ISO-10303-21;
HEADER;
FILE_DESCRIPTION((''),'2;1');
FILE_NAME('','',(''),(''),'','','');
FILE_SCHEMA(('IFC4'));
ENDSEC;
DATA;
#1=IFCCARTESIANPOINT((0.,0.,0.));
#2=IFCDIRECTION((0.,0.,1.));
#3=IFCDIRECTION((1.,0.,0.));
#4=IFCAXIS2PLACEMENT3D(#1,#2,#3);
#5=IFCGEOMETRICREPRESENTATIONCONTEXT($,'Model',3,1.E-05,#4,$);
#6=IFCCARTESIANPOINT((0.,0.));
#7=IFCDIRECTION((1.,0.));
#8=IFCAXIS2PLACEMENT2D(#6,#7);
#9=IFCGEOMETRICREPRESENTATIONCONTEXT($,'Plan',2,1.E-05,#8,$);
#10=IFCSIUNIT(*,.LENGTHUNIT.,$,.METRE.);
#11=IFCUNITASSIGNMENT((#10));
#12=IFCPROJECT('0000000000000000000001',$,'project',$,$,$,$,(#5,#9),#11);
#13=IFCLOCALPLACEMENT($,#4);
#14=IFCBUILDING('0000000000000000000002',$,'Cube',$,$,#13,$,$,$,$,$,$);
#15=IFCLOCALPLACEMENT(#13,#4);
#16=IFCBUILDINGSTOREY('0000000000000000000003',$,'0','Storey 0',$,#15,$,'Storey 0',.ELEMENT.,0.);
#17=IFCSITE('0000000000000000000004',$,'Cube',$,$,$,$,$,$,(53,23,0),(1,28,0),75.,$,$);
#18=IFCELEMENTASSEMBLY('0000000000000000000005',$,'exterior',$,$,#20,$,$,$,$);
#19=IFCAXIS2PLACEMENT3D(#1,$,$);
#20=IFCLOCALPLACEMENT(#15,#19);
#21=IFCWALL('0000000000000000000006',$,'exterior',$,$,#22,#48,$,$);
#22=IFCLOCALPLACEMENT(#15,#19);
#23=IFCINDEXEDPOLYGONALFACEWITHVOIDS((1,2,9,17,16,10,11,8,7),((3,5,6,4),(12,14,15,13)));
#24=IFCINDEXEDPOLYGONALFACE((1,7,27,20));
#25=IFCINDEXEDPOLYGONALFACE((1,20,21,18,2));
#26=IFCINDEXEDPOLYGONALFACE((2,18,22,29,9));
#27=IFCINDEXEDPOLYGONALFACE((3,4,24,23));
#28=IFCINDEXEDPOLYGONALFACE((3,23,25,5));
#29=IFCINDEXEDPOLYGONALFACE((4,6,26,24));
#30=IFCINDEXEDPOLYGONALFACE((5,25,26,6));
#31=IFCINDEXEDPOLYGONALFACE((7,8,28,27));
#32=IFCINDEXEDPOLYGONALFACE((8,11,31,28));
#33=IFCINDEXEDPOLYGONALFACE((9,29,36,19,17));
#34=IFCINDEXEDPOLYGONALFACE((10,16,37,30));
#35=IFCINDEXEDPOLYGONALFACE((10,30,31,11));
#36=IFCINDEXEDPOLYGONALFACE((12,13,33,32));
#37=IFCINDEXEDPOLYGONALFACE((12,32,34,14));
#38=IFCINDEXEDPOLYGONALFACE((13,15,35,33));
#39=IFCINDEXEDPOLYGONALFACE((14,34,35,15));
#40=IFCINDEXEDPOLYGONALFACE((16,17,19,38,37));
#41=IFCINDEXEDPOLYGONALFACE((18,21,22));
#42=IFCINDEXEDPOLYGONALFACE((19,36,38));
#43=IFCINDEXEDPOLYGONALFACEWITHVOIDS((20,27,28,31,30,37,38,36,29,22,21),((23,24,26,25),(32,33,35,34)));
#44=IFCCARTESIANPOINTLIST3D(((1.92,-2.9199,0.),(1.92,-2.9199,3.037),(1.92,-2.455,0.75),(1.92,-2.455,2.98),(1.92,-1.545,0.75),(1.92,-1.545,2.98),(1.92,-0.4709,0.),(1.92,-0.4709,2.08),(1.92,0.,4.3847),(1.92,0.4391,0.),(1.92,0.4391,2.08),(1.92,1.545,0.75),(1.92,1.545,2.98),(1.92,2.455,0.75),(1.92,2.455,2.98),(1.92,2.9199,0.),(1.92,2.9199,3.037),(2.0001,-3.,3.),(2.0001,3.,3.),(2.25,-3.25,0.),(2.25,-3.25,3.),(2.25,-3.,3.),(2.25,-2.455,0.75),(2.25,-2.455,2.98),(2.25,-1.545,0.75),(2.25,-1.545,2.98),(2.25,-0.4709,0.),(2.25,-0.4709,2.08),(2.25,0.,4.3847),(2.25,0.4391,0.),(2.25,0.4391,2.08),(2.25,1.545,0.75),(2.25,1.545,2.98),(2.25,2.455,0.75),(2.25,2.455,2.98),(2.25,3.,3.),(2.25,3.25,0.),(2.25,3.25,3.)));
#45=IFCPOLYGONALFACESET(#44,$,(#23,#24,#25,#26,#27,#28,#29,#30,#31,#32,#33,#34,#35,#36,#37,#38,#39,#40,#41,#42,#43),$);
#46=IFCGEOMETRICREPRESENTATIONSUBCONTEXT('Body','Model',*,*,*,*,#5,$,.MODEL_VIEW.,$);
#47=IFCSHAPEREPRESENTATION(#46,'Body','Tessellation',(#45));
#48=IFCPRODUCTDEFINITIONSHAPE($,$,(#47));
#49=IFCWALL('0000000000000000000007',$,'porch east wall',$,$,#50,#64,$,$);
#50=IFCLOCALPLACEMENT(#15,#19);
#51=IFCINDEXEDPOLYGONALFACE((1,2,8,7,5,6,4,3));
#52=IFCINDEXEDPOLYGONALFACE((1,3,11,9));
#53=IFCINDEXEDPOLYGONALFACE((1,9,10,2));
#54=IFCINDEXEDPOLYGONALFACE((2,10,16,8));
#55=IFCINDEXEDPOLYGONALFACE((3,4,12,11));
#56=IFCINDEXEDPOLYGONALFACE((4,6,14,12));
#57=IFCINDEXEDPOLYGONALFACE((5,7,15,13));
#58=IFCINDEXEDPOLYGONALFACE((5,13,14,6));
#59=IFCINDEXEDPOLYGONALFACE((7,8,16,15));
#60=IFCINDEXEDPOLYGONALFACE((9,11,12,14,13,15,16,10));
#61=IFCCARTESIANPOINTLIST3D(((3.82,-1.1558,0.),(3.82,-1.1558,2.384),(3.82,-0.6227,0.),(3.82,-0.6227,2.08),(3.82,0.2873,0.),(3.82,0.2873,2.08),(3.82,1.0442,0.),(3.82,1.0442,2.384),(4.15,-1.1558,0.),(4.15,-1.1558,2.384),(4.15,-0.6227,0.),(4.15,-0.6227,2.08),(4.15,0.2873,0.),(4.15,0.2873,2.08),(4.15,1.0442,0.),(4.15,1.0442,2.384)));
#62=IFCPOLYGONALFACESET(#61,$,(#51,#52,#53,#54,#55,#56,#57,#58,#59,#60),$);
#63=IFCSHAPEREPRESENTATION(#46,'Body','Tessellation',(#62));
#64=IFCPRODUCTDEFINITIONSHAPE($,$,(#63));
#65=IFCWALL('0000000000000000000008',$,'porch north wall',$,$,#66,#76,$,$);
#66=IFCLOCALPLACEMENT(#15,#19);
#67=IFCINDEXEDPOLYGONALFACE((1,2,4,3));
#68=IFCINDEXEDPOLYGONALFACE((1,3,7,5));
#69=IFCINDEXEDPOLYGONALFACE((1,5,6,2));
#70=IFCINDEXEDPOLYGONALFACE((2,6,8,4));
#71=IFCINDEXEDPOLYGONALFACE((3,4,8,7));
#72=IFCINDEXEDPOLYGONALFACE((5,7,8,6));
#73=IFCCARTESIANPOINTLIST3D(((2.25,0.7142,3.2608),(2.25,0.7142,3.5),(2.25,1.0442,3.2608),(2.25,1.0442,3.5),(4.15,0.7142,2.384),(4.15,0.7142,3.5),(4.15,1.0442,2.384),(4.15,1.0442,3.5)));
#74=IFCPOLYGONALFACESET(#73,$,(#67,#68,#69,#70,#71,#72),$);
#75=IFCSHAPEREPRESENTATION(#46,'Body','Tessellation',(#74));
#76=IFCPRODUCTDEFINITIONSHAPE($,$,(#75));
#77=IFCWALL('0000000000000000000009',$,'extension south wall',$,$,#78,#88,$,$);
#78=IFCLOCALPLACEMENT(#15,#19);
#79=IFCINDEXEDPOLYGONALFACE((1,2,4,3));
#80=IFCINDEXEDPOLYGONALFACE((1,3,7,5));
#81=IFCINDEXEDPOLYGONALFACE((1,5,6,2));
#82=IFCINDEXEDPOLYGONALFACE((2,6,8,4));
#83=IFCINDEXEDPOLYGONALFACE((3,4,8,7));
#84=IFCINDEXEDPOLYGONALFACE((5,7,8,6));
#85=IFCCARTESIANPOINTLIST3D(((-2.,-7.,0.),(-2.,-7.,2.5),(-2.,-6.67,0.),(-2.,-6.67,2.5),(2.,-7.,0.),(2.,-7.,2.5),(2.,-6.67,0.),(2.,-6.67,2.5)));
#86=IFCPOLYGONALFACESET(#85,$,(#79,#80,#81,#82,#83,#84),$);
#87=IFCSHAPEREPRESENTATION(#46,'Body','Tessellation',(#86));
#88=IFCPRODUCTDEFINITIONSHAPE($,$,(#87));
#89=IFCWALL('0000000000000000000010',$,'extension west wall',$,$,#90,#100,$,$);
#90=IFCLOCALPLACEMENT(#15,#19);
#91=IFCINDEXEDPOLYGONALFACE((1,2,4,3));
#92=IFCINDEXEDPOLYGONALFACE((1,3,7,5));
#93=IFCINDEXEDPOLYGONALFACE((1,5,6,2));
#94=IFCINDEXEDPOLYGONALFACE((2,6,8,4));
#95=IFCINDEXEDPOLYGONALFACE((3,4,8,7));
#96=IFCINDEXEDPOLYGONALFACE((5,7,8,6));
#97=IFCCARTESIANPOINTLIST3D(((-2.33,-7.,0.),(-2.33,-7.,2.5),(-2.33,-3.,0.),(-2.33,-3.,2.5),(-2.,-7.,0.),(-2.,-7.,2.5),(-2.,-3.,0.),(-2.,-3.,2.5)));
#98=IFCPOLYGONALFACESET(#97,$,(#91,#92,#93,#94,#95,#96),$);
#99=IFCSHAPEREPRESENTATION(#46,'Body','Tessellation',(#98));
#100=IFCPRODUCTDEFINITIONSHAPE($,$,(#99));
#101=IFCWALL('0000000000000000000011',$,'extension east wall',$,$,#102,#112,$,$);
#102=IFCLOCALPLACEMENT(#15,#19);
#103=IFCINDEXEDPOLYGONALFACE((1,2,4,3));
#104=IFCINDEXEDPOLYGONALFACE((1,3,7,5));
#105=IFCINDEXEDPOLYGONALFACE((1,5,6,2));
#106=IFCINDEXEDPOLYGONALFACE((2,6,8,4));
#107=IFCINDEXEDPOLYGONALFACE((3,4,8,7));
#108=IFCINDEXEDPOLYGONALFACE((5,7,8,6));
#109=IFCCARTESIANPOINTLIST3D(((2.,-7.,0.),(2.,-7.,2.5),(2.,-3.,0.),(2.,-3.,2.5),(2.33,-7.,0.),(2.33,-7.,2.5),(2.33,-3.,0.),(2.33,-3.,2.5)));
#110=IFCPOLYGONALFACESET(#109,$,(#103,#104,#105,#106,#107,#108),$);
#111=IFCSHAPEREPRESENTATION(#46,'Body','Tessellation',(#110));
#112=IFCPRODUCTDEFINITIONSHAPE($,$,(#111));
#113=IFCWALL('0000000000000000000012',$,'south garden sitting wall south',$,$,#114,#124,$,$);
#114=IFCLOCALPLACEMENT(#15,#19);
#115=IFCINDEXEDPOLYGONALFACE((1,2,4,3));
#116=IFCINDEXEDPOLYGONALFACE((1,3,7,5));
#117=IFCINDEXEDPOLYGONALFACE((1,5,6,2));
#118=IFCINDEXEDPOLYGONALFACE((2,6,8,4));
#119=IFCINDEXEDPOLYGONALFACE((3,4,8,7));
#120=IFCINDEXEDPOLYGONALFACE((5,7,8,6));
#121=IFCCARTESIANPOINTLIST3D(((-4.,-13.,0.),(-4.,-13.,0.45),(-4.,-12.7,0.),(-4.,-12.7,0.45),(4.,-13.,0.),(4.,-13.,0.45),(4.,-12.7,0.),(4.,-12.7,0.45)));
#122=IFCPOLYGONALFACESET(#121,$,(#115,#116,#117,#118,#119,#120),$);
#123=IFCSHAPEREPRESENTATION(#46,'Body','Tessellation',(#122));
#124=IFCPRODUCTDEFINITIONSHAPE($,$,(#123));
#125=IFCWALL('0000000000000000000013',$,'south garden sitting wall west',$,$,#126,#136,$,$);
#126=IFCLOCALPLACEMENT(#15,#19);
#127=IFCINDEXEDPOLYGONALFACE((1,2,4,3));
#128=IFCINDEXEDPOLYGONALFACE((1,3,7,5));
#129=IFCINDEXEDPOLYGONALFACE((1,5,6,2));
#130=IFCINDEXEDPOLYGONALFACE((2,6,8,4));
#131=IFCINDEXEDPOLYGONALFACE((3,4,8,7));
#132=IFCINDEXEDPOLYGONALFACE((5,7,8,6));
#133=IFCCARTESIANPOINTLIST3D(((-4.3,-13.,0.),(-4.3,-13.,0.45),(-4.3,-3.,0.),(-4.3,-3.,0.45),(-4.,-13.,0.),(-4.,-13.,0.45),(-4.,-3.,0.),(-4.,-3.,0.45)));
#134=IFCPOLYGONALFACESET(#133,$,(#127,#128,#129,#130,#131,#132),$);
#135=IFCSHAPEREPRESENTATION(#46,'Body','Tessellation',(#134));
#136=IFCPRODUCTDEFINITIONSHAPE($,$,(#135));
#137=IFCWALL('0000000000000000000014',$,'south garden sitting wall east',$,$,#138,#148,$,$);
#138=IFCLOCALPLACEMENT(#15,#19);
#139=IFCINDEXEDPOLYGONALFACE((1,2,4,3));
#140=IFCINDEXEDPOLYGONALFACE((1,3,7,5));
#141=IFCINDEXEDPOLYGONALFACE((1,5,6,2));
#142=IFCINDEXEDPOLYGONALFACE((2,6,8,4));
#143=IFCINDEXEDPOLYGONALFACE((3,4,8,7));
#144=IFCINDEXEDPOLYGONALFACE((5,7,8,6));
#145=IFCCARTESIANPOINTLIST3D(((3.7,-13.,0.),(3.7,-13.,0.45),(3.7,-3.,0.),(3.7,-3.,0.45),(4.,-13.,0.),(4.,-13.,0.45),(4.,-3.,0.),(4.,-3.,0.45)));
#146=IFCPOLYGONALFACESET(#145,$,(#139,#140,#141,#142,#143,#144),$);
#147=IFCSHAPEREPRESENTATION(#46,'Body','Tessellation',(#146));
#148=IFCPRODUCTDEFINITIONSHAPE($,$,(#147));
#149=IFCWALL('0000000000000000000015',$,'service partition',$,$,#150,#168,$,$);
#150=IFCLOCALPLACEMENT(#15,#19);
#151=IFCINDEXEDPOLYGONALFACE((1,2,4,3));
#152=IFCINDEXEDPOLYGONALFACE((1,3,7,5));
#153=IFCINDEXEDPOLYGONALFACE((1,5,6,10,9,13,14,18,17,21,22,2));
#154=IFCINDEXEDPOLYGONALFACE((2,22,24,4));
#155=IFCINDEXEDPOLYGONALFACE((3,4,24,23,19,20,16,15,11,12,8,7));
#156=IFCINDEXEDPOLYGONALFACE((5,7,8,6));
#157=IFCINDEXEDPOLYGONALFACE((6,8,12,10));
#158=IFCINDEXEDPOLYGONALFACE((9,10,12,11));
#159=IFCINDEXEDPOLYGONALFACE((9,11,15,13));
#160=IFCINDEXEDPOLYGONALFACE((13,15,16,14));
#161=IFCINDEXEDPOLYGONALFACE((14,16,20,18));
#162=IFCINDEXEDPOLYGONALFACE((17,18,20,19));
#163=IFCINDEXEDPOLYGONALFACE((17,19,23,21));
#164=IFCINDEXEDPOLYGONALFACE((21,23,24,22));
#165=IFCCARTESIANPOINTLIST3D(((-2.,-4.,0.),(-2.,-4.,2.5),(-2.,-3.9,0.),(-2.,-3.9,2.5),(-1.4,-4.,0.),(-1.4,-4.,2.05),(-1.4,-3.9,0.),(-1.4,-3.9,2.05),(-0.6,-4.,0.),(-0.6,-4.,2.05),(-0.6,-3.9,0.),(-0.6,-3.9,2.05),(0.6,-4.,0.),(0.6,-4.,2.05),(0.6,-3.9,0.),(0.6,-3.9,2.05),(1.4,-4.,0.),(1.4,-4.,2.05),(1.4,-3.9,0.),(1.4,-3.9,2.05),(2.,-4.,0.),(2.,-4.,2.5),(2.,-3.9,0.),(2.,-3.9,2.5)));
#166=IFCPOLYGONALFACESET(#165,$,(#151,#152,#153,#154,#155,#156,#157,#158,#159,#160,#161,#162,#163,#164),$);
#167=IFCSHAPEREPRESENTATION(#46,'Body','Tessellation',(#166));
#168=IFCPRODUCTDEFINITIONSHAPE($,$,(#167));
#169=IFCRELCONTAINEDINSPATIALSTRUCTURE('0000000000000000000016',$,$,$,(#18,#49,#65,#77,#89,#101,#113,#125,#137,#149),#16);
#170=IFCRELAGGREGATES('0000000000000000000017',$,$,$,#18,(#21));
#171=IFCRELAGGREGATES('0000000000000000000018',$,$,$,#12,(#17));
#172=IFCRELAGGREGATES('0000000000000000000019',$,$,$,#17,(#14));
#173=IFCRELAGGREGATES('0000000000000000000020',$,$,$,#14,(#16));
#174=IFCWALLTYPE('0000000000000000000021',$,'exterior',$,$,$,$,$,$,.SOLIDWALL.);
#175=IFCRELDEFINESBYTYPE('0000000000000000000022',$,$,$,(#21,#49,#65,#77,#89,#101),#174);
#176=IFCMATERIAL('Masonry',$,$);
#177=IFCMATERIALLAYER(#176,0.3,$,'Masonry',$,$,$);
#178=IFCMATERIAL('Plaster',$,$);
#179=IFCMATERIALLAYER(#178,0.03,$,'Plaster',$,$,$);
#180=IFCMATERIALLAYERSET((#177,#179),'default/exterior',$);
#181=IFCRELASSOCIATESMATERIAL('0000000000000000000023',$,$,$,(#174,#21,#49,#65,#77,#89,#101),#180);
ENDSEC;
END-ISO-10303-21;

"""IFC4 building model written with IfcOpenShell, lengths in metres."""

from ifc_helpers import new_model, si_unit, frame, origin, origin_with_axes, origin_2d_with_axis, place, context, subcontext, project, spatial, polyline, line, indexed_curve, outline, extrude, clip, halfspace, bounded_halfspace, source, transform, mapped, material, layer, layer_set, layer_usage, type_object, element, aggregate, save


model = new_model("IFC4")

# Units and contexts
model_context = context("Model", 3, precision=1e-05, world=origin_with_axes())
plan_context = context("Plan", 2, precision=1e-05, world=origin_2d_with_axis())
body_context = subcontext(model_context, "Body", "Model", "MODEL_VIEW")
ifc_project = project(units=[si_unit("LENGTHUNIT", "METRE")], contexts=[model_context, plan_context])

# Site, building, storey
site = spatial("IfcSite", under=ifc_project, Name="Cube", RefLatitude=(53, 23, 0), RefLongitude=(1, 28, 0), RefElevation=75.0)
building_placement = place(None, origin_with_axes())
building = spatial("IfcBuilding", under=site, at=building_placement, Name="Cube")
storey_placement = place(building_placement, origin_with_axes())
storey = spatial("IfcBuildingStorey", under=building, at=storey_placement, Name="0", Description="Storey 0", LongName="Storey 0", CompositionType="ELEMENT", Elevation=0.0)

# Element assembly, wall, openings
ifc_material_1 = material(Name="Masonry")
ifc_layer_1 = layer(ifc_material_1, 0.3, Name="Masonry")
ifc_material_2 = material(Name="Plaster")
ifc_layer_2 = layer(ifc_material_2, 0.03, Name="Plaster")
ifc_layer_set_1 = layer_set([ifc_layer_1, ifc_layer_2], Name="default/exterior")
wall_type = type_object("IfcWallType", Name="exterior", PredefinedType="SOLIDWALL", material=ifc_layer_set_1)
assembly_1_placement = place(storey_placement, frame((2.0, -3.0, 0.0), z_axis=(0.0, 0.0, 1.0), x_axis=(0.0, 1.0, 0.0)))
assembly_1 = element("IfcElementAssembly", 1, at=assembly_1_placement, inside=storey, Name="exterior")
ifc_layer_usage_1 = layer_usage(ifc_layer_set_1, "AXIS2", "POSITIVE", -0.25)
wall_1_placement = place(assembly_1_placement, origin_with_axes())
wall_1 = element("IfcWall", 2, at=wall_1_placement, type_object=wall_type, material=ifc_layer_usage_1, Name="exterior", context=body_context, shape_type="Clipping", body=[
    clip(clip(clip(clip(extrude(outline(polyline([(0.0801, 0.08), (-0.25, -0.25), (6.25, -0.25), (5.9199, 0.08), (0.0801, 0.08)])), origin(), (0.0, 0.0, 1.0), 4.385), bounded_halfspace(frame((6.0, 0.0, 3.0), z_axis=(0.419069, 0.0, 0.907954), x_axis=(0.0, -1.0, 0.0)), False, origin(), polyline([(6.0, -1.0), (3.0, -1.0), (3.0, 1.0), (6.0, 1.0), (6.0, -1.0)]))), bounded_halfspace(frame((6.0, 0.0, 3.0), z_axis=(0.0, 0.0, 1.0), x_axis=(0.0, 1.0, 0.0)), False, origin(), polyline([(6.0, 1.0), (7.0, 1.0), (7.0, -1.0), (6.0, -1.0), (6.0, 1.0)]))), bounded_halfspace(frame((3.0, 0.0, 4.3847), z_axis=(-0.419069, 0.0, 0.907954), x_axis=(0.0, -1.0, 0.0)), False, origin(), polyline([(3.0, -1.0), (0.0, -1.0), (0.0, 1.0), (3.0, 1.0), (3.0, -1.0)]))), bounded_halfspace(frame((0.0, 0.0, 3.0), z_axis=(0.0, 0.0, 1.0), x_axis=(0.0, -1.0, 0.0)), False, origin(), polyline([(0.0, -1.0), (-1.0, -1.0), (-1.0, 1.0), (0.0, 1.0), (0.0, -1.0)]))),
])
opening_1_placement = place(wall_1_placement, frame((0.545, -0.25, 0.75), z_axis=(0.0, 0.0, 1.0), x_axis=(1.0, 0.0, 0.0)))
element("IfcOpeningElement", 3, at=opening_1_placement, cuts=wall_1, PredefinedType="OPENING", context=body_context, shape_type="SweptSolid", body=[
    extrude(outline(polyline([(0.0, -0.02), (0.91, -0.02), (0.91, 0.35), (0.0, 0.35), (0.0, -0.02)])), origin(), (0.0, 0.0, 1.0), 2.23),
])
opening_2_placement = place(wall_1_placement, frame((4.545, -0.25, 0.75), z_axis=(0.0, 0.0, 1.0), x_axis=(1.0, 0.0, 0.0)))
element("IfcOpeningElement", 4, at=opening_2_placement, cuts=wall_1, PredefinedType="OPENING", context=body_context, shape_type="SweptSolid", body=[
    extrude(outline(polyline([(0.0, -0.02), (0.91, -0.02), (0.91, 0.35), (0.0, 0.35), (0.0, -0.02)])), origin(), (0.0, 0.0, 1.0), 2.23),
])
shared_shape_1 = source(origin_with_axes(), body_context, "Body", "SweptSolid", [
    extrude(outline(indexed_curve([(0.0, 0.0), (0.91, 0.0), (0.91, 2.08), (0.0, 2.08)], segments=[line(1, 2, 3, 4, 1)])), frame((0.0, -0.6, 0.0), z_axis=(0.0, -1.0, 0.0), x_axis=(1.0, 0.0, 0.0)), (0.0, 0.0, -1.0), 1.2),
])
opening_3_placement = place(wall_1_placement, frame((2.5291, -0.25, 0.0), z_axis=(0.0, 0.0, 1.0), x_axis=(1.0, 0.0, 0.0)))
element("IfcOpeningElement", 5, at=opening_3_placement, cuts=wall_1, PredefinedType="OPENING", context=body_context, shape_type="MappedRepresentation", body=[
    mapped(shared_shape_1, transform((0.0, 0.0, 0.0), x_axis=(1.0, 0.0, 0.0), y_axis=(0.0, 1.0, 0.0), z_axis=(0.0, 0.0, 1.0), scale=1.0)),
])
aggregate(assembly_1, [wall_1])

# Wall, opening
ifc_layer_usage_2 = layer_usage(ifc_layer_set_1, "AXIS2", "POSITIVE", 0.0)
wall_2_placement = place(storey_placement, frame((4.15, -1.1558, 0.0), z_axis=(0.0, 0.0, 1.0), x_axis=(0.0, 1.0, 0.0)))
wall_2 = element("IfcWall", 6, at=wall_2_placement, inside=storey, type_object=wall_type, material=ifc_layer_usage_2, Name="porch east wall", context=body_context, shape_type="SweptSolid", body=[
    extrude(outline(indexed_curve([(0.0, 0.0), (0.0, 0.33), (2.2, 0.33), (2.2, 0.0), (0.0, 0.0)], self_intersect=False)), origin_with_axes(), (0.0, 0.0, 1.0), 2.384),
])
shared_shape_2 = source(origin_with_axes(), body_context, "Body", "SweptSolid", [
    extrude(outline(indexed_curve([(0.0, 0.0), (0.91, 0.0), (0.91, 2.08), (0.0, 2.08)], segments=[line(1, 2, 3, 4, 1)])), frame((0.0, -0.6, 0.0), z_axis=(0.0, -1.0, 0.0), x_axis=(1.0, 0.0, 0.0)), (0.0, 0.0, -1.0), 1.2),
])
opening_4_placement = place(wall_2_placement, frame((0.5331, 0.0, 0.0), z_axis=(0.0, 0.0, 1.0), x_axis=(1.0, 0.0, 0.0)))
element("IfcOpeningElement", 7, at=opening_4_placement, cuts=wall_2, PredefinedType="OPENING", context=body_context, shape_type="MappedRepresentation", body=[
    mapped(shared_shape_2, transform((0.0, 0.0, 0.0), x_axis=(1.0, 0.0, 0.0), y_axis=(0.0, 1.0, 0.0), z_axis=(0.0, 0.0, 1.0), scale=1.0)),
])

# Walls
ifc_layer_usage_3 = layer_usage(ifc_layer_set_1, "AXIS2", "POSITIVE", 0.0)
wall_3_placement = place(storey_placement, frame((4.15, 1.0442, 0.0), z_axis=(0.0, 0.0, 1.0), x_axis=(-1.0, 0.0, 0.0)))
element("IfcWall", 8, at=wall_3_placement, inside=storey, type_object=wall_type, material=ifc_layer_usage_3, Name="porch north wall", context=body_context, shape_type="Clipping", body=[
    clip(extrude(outline(indexed_curve([(0.0, 0.0), (0.0, 0.33), (1.9, 0.33), (1.9, 0.0), (0.0, 0.0)], self_intersect=False)), origin_with_axes(), (0.0, 0.0, 1.0), 3.5), halfspace(frame((0.0, 0.0, 2.384), z_axis=(0.419, 0.0, -0.908), x_axis=(0.0, -1.0, 0.0)), False)),
])
ifc_layer_usage_4 = layer_usage(ifc_layer_set_1, "AXIS2", "POSITIVE", 0.0)
for number, where, z_axis, x_axis, name in (
    (9, (-2.0, -7.0, 0.0), (0.0, 0.0, 1.0), (1.0, 0.0, 0.0), "extension south wall"),
    (10, (-2.0, -7.0, 0.0), (0.0, 0.0, 1.0), (0.0, 1.0, 0.0), "extension west wall"),
    (11, (2.0, -3.0, 0.0), (0.0, 0.0, 1.0), (0.0, -1.0, 0.0), "extension east wall"),
):
    element("IfcWall", number, at=place(storey_placement, frame(where, z_axis=z_axis, x_axis=x_axis)), inside=storey, type_object=wall_type, material=ifc_layer_usage_4, Name=name, context=body_context, shape_type="SweptSolid", body=[
        extrude(outline(indexed_curve([(0.0, 0.0), (0.0, 0.33), (4.0, 0.33), (4.0, 0.0), (0.0, 0.0)], self_intersect=False)), origin_with_axes(), (0.0, 0.0, 1.0), 2.5),
    ])
wall_4_placement = place(storey_placement, frame((-4.0, -13.0, 0.0), z_axis=(0.0, 0.0, 1.0), x_axis=(1.0, 0.0, 0.0)))
element("IfcWall", 12, at=wall_4_placement, inside=storey, Name="south garden sitting wall south", context=body_context, shape_type="SweptSolid", body=[
    extrude(outline(indexed_curve([(0.0, 0.0), (0.0, 0.3), (8.0, 0.3), (8.0, 0.0), (0.0, 0.0)], self_intersect=False)), origin_with_axes(), (0.0, 0.0, 1.0), 0.45),
])
for number, where, z_axis, x_axis, name in (
    (13, (-4.0, -13.0, 0.0), (0.0, 0.0, 1.0), (0.0, 1.0, 0.0), "south garden sitting wall west"),
    (14, (4.0, -13.0, 0.0), (0.0, 0.0, 1.0), (0.0, 1.0, 0.0), "south garden sitting wall east"),
):
    element("IfcWall", number, at=place(storey_placement, frame(where, z_axis=z_axis, x_axis=x_axis)), inside=storey, Name=name, context=body_context, shape_type="SweptSolid", body=[
        extrude(outline(indexed_curve([(0.0, 0.0), (0.0, 0.3), (10.0, 0.3), (10.0, 0.0), (0.0, 0.0)], self_intersect=False)), origin_with_axes(), (0.0, 0.0, 1.0), 0.45),
    ])

# Wall, openings
wall_5_placement = place(storey_placement, frame((-2.0, -4.0, 0.0), z_axis=(0.0, 0.0, 1.0), x_axis=(1.0, 0.0, 0.0)))
wall_5 = element("IfcWall", 15, at=wall_5_placement, inside=storey, Name="service partition", context=body_context, shape_type="SweptSolid", body=[
    extrude(outline(indexed_curve([(0.0, 0.0), (0.0, 0.1), (4.0, 0.1), (4.0, 0.0), (0.0, 0.0)], self_intersect=False)), origin_with_axes(), (0.0, 0.0, 1.0), 2.5),
])
opening_5_placement = place(wall_5_placement, frame((0.6, -0.05, 0.0), z_axis=(0.0, 0.0, 1.0), x_axis=(1.0, 0.0, 0.0)))
element("IfcOpeningElement", 16, at=opening_5_placement, cuts=wall_5, context=body_context, shape_type="SweptSolid", body=[
    extrude(outline(indexed_curve([(0.0, 0.0), (0.0, 0.3), (0.8, 0.3), (0.8, 0.0), (0.0, 0.0)], self_intersect=False)), origin_with_axes(), (0.0, 0.0, 1.0), 2.05),
])
opening_6_placement = place(wall_5_placement, frame((2.6, -0.05, 0.0), z_axis=(0.0, 0.0, 1.0), x_axis=(1.0, 0.0, 0.0)))
element("IfcOpeningElement", 17, at=opening_6_placement, cuts=wall_5, context=body_context, shape_type="SweptSolid", body=[
    extrude(outline(indexed_curve([(0.0, 0.0), (0.0, 0.3), (0.8, 0.3), (0.8, 0.0), (0.0, 0.0)], self_intersect=False)), origin_with_axes(), (0.0, 0.0, 1.0), 2.05),
])

save(model, "model.ifc")
